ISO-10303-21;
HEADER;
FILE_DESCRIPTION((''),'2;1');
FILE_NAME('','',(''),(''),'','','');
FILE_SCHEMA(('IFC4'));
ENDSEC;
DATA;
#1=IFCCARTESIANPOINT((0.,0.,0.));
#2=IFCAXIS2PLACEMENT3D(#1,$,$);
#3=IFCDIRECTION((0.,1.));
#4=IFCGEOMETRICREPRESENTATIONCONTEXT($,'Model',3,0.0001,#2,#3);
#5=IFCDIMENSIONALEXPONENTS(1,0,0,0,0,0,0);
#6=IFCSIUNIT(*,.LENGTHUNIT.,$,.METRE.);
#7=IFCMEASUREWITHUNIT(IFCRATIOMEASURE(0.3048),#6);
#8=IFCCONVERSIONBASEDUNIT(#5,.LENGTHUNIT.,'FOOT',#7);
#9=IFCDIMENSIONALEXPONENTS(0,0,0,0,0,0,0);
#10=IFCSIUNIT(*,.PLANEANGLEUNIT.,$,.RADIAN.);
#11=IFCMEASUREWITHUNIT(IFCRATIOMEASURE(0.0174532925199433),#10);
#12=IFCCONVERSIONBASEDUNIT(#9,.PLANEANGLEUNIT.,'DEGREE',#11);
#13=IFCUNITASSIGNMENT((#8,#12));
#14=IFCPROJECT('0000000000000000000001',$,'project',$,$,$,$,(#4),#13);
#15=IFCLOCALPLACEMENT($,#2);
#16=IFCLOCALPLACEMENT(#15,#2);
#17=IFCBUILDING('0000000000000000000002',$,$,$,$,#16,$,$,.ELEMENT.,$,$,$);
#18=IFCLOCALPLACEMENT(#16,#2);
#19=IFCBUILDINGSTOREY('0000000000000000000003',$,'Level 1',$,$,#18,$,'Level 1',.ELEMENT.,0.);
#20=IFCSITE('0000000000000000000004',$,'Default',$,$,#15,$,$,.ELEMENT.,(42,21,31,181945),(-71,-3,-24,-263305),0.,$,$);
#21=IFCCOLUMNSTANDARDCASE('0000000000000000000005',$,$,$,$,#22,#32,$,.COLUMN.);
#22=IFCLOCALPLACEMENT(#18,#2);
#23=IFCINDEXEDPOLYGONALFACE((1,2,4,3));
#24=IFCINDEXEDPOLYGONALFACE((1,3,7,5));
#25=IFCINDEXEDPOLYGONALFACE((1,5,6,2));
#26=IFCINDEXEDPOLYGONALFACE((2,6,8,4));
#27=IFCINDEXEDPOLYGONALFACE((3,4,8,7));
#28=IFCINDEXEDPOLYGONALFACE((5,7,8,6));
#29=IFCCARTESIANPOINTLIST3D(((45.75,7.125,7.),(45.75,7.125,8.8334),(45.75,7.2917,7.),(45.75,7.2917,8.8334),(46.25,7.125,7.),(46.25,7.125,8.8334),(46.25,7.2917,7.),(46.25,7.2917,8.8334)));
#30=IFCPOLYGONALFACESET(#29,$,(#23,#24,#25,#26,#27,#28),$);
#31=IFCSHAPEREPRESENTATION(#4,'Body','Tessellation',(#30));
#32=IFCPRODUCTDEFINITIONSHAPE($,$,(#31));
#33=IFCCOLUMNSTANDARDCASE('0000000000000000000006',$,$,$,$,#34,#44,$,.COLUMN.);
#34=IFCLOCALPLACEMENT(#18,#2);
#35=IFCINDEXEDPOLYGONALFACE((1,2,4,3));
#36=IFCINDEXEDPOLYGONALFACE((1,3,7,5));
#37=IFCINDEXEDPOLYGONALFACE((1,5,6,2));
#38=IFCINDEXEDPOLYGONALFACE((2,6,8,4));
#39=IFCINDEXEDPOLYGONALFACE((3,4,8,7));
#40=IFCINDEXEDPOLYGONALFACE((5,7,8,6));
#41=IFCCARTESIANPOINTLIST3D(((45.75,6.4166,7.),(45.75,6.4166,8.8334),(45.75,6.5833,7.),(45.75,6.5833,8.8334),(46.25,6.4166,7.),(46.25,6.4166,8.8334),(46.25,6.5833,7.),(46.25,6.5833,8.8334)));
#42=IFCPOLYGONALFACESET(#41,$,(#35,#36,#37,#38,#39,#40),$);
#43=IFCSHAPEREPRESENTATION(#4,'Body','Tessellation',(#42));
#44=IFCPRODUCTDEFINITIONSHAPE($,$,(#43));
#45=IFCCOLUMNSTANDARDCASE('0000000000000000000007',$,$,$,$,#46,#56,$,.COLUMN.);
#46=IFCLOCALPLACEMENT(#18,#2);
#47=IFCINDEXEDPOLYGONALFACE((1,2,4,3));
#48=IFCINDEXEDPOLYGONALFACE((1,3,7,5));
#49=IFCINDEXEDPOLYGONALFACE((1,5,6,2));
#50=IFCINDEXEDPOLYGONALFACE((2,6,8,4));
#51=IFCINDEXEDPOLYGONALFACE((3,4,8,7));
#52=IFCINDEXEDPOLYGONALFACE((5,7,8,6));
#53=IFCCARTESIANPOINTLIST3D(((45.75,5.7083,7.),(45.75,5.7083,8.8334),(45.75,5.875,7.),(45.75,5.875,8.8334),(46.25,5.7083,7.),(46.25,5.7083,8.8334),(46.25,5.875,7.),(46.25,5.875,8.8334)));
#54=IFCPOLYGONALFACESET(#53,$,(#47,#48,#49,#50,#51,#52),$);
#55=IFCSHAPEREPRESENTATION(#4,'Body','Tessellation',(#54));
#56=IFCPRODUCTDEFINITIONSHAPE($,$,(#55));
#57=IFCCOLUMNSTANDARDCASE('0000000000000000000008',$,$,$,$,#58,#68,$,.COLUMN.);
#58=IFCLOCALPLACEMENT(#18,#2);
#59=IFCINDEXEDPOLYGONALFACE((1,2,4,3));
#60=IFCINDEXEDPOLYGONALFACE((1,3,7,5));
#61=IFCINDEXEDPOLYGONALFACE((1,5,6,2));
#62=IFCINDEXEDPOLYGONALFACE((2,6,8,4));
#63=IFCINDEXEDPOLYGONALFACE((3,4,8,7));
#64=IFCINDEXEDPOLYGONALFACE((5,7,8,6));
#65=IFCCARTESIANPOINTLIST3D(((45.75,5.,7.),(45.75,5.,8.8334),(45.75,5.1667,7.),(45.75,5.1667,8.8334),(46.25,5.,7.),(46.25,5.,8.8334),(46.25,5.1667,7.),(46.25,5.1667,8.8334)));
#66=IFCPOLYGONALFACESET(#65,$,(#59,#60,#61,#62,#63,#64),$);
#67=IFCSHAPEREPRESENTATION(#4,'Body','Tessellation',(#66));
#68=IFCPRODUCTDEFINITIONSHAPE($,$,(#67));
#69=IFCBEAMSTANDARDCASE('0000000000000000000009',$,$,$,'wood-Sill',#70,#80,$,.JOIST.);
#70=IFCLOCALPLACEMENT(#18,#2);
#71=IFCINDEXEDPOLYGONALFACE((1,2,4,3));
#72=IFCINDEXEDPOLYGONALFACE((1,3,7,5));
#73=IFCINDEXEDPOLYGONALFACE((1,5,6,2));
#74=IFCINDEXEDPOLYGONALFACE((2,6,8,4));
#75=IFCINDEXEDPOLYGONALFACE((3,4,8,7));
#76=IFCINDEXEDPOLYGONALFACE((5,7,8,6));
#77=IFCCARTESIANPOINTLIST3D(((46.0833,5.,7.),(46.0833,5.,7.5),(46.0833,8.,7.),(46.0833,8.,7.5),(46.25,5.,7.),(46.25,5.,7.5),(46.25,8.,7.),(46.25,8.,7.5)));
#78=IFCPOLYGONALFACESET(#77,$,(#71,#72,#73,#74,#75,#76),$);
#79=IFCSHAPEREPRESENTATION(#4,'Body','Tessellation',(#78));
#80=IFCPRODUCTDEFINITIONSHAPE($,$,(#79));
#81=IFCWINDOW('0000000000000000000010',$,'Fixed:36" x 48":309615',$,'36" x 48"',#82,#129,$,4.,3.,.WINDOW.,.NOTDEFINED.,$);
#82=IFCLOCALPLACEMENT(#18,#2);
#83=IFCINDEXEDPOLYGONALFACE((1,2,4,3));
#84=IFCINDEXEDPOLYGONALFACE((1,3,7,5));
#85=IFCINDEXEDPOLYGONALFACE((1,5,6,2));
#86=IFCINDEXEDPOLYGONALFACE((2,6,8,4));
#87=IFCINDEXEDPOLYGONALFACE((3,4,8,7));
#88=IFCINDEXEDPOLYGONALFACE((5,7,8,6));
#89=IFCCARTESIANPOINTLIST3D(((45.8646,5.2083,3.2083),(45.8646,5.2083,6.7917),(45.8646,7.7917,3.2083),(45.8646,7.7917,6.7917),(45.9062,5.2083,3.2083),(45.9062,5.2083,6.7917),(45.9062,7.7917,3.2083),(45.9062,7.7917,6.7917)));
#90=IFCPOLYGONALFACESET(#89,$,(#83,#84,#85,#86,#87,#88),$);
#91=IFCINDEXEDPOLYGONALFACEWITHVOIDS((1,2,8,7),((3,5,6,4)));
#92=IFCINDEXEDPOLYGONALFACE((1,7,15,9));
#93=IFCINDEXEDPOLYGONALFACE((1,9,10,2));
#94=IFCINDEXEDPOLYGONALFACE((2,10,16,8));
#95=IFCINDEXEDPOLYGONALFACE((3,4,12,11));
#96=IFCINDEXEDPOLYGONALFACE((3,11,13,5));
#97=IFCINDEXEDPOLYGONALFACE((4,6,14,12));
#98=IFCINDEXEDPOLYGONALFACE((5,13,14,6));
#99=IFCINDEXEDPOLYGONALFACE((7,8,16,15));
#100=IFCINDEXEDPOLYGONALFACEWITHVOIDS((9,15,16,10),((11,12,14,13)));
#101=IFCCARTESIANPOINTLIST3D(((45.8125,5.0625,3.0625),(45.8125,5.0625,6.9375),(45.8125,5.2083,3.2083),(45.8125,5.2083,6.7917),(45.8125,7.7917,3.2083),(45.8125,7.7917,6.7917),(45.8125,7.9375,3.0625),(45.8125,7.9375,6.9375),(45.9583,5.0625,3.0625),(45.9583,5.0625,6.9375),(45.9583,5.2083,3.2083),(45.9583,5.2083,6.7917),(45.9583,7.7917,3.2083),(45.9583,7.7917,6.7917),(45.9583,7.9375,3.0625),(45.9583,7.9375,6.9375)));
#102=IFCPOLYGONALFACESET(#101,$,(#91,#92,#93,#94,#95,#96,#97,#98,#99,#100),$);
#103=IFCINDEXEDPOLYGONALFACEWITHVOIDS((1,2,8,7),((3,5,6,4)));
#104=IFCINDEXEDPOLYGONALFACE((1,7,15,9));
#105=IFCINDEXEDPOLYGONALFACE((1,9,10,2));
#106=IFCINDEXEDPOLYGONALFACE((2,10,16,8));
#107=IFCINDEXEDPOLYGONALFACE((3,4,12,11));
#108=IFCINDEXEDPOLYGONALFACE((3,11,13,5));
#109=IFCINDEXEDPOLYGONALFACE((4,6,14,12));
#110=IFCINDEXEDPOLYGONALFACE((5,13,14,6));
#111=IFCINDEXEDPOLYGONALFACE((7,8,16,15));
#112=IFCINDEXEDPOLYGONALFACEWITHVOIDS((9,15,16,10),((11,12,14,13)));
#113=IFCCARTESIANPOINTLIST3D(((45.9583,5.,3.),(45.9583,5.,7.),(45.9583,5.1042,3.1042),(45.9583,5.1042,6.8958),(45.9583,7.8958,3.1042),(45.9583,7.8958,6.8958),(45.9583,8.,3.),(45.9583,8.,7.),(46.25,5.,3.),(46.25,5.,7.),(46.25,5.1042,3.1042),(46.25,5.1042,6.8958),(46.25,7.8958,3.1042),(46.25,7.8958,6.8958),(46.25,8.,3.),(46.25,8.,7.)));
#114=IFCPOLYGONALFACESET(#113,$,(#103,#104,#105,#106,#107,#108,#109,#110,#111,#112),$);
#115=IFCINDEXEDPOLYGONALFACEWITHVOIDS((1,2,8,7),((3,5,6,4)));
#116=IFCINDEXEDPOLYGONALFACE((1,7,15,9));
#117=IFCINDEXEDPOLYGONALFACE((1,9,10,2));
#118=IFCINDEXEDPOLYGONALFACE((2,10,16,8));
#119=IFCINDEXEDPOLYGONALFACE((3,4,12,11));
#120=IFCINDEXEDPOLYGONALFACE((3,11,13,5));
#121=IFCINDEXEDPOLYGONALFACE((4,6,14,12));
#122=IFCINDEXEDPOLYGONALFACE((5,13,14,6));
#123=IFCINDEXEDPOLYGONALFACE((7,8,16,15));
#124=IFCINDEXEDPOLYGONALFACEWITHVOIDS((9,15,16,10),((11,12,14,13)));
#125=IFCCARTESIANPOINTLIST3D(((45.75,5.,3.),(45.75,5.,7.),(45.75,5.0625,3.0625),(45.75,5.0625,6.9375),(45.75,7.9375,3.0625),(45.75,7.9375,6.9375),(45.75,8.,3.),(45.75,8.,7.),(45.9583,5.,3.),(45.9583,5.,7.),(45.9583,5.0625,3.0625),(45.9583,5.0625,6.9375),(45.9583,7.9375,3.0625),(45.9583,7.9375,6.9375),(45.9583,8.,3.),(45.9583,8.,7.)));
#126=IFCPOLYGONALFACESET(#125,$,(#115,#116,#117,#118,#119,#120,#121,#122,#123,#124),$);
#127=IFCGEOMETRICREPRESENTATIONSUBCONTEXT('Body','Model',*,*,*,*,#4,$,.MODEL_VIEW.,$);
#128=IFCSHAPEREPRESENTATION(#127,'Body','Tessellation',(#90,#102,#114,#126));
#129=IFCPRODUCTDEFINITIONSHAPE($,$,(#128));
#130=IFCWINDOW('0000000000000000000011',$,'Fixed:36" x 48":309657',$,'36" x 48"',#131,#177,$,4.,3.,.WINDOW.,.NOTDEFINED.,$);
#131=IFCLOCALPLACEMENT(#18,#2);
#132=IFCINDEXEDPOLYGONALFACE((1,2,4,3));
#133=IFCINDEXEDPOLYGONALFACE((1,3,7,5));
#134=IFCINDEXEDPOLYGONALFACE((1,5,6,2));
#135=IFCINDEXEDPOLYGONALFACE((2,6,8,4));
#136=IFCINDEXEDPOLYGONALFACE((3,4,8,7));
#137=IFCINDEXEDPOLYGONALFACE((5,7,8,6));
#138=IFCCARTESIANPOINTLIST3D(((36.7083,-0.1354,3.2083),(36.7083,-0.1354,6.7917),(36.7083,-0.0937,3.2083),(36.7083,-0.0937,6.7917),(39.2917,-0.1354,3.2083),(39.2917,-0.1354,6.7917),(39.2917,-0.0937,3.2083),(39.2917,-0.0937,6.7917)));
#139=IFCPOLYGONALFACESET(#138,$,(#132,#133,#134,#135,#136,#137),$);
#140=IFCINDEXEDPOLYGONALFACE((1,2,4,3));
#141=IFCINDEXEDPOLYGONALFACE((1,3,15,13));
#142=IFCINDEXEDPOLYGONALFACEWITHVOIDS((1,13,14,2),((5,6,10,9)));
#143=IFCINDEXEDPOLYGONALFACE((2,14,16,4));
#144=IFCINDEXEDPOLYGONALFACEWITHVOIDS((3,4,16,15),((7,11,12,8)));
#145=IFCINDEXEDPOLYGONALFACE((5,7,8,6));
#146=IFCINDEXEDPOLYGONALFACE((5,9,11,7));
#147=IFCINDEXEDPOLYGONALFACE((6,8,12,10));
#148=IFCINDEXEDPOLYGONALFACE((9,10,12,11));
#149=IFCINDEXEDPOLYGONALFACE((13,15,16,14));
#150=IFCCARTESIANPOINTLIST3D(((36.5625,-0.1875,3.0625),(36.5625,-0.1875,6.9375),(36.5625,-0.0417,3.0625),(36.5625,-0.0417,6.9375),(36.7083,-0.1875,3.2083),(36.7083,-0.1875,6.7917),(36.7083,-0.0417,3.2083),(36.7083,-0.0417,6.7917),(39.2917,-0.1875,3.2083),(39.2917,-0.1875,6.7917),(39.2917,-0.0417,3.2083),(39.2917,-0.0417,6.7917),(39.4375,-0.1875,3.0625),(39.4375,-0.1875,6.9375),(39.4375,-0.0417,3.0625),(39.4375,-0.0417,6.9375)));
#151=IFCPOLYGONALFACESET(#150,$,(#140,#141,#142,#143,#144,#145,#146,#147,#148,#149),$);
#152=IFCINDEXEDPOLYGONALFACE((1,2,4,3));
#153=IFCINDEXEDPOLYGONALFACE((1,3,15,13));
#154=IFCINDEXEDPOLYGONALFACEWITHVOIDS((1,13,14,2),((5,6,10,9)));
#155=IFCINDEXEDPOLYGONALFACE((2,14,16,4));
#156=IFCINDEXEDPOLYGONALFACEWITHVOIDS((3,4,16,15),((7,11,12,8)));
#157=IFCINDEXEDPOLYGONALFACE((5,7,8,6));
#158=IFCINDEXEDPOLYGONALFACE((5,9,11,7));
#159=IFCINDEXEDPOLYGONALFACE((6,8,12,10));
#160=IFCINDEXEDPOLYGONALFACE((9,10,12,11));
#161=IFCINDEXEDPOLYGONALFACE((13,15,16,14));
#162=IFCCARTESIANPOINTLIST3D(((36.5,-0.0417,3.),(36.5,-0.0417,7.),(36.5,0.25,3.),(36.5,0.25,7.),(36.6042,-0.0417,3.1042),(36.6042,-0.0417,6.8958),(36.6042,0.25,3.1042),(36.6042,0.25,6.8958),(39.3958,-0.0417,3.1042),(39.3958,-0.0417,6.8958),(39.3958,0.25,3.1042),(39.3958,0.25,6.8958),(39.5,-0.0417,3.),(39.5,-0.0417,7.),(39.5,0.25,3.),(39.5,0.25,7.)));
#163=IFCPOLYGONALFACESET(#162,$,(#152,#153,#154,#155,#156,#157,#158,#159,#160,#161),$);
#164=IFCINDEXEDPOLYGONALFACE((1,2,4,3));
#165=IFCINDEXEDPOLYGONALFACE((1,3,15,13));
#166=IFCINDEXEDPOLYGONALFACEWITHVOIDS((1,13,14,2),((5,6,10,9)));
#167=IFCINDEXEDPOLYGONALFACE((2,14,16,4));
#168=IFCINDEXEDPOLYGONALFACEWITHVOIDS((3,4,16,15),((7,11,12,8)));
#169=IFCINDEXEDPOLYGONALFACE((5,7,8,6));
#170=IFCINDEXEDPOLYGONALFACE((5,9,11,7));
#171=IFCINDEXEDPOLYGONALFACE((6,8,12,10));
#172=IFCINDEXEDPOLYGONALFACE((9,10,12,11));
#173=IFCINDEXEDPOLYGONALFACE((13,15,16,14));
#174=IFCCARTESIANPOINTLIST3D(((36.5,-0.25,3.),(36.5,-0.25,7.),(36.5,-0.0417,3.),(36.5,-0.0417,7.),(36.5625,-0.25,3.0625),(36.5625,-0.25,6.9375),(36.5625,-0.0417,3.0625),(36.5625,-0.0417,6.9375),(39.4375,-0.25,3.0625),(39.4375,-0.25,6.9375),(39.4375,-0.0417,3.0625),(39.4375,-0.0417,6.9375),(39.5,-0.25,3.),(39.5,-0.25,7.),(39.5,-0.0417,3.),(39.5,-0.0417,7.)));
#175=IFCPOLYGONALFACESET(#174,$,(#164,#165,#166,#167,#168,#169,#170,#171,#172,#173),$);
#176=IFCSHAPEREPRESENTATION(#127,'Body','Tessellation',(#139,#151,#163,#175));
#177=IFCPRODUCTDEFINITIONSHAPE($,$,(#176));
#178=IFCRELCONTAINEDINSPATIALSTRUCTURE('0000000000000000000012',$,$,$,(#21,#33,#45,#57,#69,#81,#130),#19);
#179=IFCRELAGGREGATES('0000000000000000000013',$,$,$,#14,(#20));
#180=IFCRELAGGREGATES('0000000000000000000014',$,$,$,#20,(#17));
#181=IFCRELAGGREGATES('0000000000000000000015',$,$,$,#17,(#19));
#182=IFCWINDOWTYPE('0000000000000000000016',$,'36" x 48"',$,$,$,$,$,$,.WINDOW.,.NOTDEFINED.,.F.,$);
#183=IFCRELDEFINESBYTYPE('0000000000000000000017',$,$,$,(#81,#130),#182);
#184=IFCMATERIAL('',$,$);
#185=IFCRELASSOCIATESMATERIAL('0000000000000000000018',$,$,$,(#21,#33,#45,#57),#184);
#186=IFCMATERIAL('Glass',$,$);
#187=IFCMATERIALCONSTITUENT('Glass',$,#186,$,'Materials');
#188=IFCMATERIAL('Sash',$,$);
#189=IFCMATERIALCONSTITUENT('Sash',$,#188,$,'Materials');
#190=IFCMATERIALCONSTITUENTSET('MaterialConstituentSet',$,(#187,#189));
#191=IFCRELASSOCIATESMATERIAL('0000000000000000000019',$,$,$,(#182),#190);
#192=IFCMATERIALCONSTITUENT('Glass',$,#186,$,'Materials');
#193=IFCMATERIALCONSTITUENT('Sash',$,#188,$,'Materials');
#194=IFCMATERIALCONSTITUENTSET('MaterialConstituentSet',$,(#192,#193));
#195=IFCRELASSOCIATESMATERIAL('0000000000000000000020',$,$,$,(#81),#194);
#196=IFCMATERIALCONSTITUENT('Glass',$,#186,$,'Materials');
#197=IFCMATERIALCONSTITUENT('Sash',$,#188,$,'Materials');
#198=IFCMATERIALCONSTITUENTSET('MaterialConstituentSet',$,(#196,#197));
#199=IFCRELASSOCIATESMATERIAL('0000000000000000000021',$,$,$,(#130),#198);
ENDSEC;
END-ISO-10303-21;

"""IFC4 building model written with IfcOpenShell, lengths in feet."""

from ifc_helpers import new_model, entity, si_unit, converted_unit, direction, frame, frame_2d, origin, origin_with_axes, place, context, subcontext, project, spatial, polyline, rectangle, outline, extrude, source, transform, mapped, material, constituent, constituent_set, type_object, type_shapes, element, save


model = new_model("IFC4")

# Units and contexts
model_context = context("Model", 3, precision=0.0001, world=origin(), true_north=direction((0.0, 1.0)))
body_context = subcontext(model_context, "Body", "Model", "MODEL_VIEW")
ifc_project = project(units=[converted_unit("LENGTHUNIT", "FOOT", entity("IfcRatioMeasure", 0.3048), si_unit("LENGTHUNIT", "METRE"), dimensions=[1, 0, 0, 0, 0, 0, 0]), converted_unit("PLANEANGLEUNIT", "DEGREE", entity("IfcRatioMeasure", 0.0174532925199433), si_unit("PLANEANGLEUNIT", "RADIAN"), dimensions=[0, 0, 0, 0, 0, 0, 0])], contexts=[model_context])

# Site, building, storey
site_placement = place(None, origin())
site = spatial("IfcSite", under=ifc_project, at=site_placement, Name="Default", CompositionType="ELEMENT", RefLatitude=(42, 21, 31, 181945), RefLongitude=(-71, -3, -24, -263305), RefElevation=0.0)
building_placement = place(site_placement, origin())
building = spatial("IfcBuilding", under=site, at=building_placement, CompositionType="ELEMENT")
storey_placement = place(building_placement, origin())
storey = spatial("IfcBuildingStorey", under=building, at=storey_placement, Name="Level 1", LongName="Level 1", CompositionType="ELEMENT", Elevation=0.0)

# Columns
placement_1 = place(storey_placement, frame((46.0, 46.25, 0.0), z_axis=(0.0, 0.0, 1.0), x_axis=(0.0, -1.0, 0.0)))
ifc_material_1 = material(Name="")
for number, where, z_axis, x_axis in (
    (1, (39.0417, 0.0, 7.0), (0.0, 0.0, 1.0), (1.0, 0.0, 0.0)),
    (2, (39.7501, 0.0, 7.0), (0.0, 0.0, 1.0), (1.0, 0.0, 0.0)),
    (3, (40.4584, 0.0, 7.0), (0.0, 0.0, 1.0), (1.0, 0.0, 0.0)),
    (4, (41.1667, 0.0, 7.0), (0.0, 0.0, 1.0), (1.0, 0.0, 0.0)),
):
    element("IfcColumnStandardCase", number, at=place(placement_1, frame(where, z_axis=z_axis, x_axis=x_axis)), inside=storey, material=ifc_material_1, PredefinedType="COLUMN", context=model_context, shape_type="SweptSolid", body=[
        extrude(rectangle(XDim=0.1667, YDim=0.5), origin(), (0.0, 0.0, 1.0), 1.8334),
    ])

# Beam
for number, where, z_axis, x_axis in (
    (5, (38.25, 0.1667, 7.25), (1.0, 0.0, 0.0), (0.0, 0.0, 1.0)),
):
    element("IfcBeamStandardCase", number, at=place(placement_1, frame(where, z_axis=z_axis, x_axis=x_axis)), inside=storey, ObjectType="wood-Sill", PredefinedType="JOIST", context=model_context, shape_type="SweptSolid", body=[
        extrude(rectangle(XDim=0.5, YDim=0.1667), origin_with_axes(), (0.0, 0.0, 1.0), 3.0),
    ])

# Windows
ifc_material_2 = material(Name="Glass")
ifc_constituent_1 = constituent(ifc_material_2, Name="Glass", Category="Materials")
ifc_material_3 = material(Name="Sash")
ifc_constituent_2 = constituent(ifc_material_3, Name="Sash", Category="Materials")
ifc_constituent_set_1 = constituent_set(constituents=[ifc_constituent_1, ifc_constituent_2], Name="MaterialConstituentSet")
ifc_constituent_3 = constituent(ifc_material_2, Name="Glass", Category="Materials")
ifc_constituent_4 = constituent(ifc_material_3, Name="Sash", Category="Materials")
ifc_constituent_set_2 = constituent_set(constituents=[ifc_constituent_3, ifc_constituent_4], Name="MaterialConstituentSet")
window_type = type_object("IfcWindowType", Name="36\" x 48\"", ParameterTakesPrecedence=False, PartitioningType="NOTDEFINED", PredefinedType="WINDOW", material=ifc_constituent_set_2)
shared_shape = source(origin(), body_context, "Body", "SweptSolid", [
    extrude(rectangle(XDim=0.0417, YDim=2.5833, at=frame_2d((0.0, 0.0), x_axis=(1.0, 0.0))), frame((1.5, 0.3646, 0.2083), z_axis=(0.0, 0.0, 1.0), x_axis=(0.0, 1.0, 0.0)), (0.0, 0.0, 1.0), 3.5833),
    extrude(outline(polyline([(-1.4375, -1.9375), (1.4375, -1.9375), (1.4375, 1.9375), (-1.4375, 1.9375), (-1.4375, -1.9375)]), holes=[polyline([(-1.2917, -1.7917), (-1.2917, 1.7917), (1.2917, 1.7917), (1.2917, -1.7917), (-1.2917, -1.7917)])]), frame((1.5, 0.2917, 2.0), z_axis=(0.0, 1.0, 0.0), x_axis=(1.0, 0.0, 0.0)), (0.0, 0.0, 1.0), 0.1458),
    extrude(outline(polyline([(-1.5, -2.0), (1.5, -2.0), (1.5, 2.0), (-1.5, 2.0), (-1.5, -2.0)]), holes=[polyline([(-1.3958, -1.8958), (-1.3958, 1.8958), (1.3958, 1.8958), (1.3958, -1.8958), (-1.3958, -1.8958)])]), frame((1.5, 0.0, 2.0), z_axis=(0.0, 1.0, 0.0), x_axis=(1.0, 0.0, 0.0)), (0.0, 0.0, 1.0), 0.2917),
    extrude(outline(polyline([(-2.0, -1.5), (2.0, -1.5), (2.0, 1.5), (-2.0, 1.5), (-2.0, -1.5)]), holes=[polyline([(-1.9375, -1.4375), (-1.9375, 1.4375), (1.9375, 1.4375), (1.9375, -1.4375), (-1.9375, -1.4375)])]), frame((1.5, 0.2917, 2.0), z_axis=(0.0, 1.0, 0.0), x_axis=(0.0, 0.0, -1.0)), (0.0, 0.0, 1.0), 0.2083),
])
type_shapes(window_type, [shared_shape])
placement_2 = place(placement_1, frame((41.25, 0.25, 3.0)))
window_1_placement = place(placement_2, frame((0.0, 0.0, 0.0), z_axis=(0.0, 0.0, 1.0), x_axis=(-1.0, 0.0, 0.0)))
element("IfcWindow", 6, at=window_1_placement, inside=storey, type_object=window_type, material=ifc_constituent_set_1, Name="Fixed:36\" x 48\":309615", ObjectType="36\" x 48\"", OverallHeight=4.0, OverallWidth=3.0, PartitioningType="NOTDEFINED", PredefinedType="WINDOW", context=body_context, shape_type="MappedRepresentation", body=[
    mapped(shared_shape, transform((0.0, 0.0, 0.0), scale=1.0)),
])
ifc_constituent_5 = constituent(ifc_material_2, Name="Glass", Category="Materials")
ifc_constituent_6 = constituent(ifc_material_3, Name="Sash", Category="Materials")
ifc_constituent_set_3 = constituent_set(constituents=[ifc_constituent_5, ifc_constituent_6], Name="MaterialConstituentSet")
placement_3 = place(storey_placement, frame((46.25, 0.0, 0.0), z_axis=(0.0, 0.0, 1.0), x_axis=(-1.0, 0.0, 0.0)))
placement_4 = place(placement_3, frame((6.75, -0.25, 3.0)))
window_2_placement = place(placement_4, origin())
element("IfcWindow", 7, at=window_2_placement, inside=storey, type_object=window_type, material=ifc_constituent_set_3, Name="Fixed:36\" x 48\":309657", ObjectType="36\" x 48\"", OverallHeight=4.0, OverallWidth=3.0, PartitioningType="NOTDEFINED", PredefinedType="WINDOW", context=body_context, shape_type="MappedRepresentation", body=[
    mapped(shared_shape, transform((0.0, 0.0, 0.0), scale=1.0)),
])

save(model, "model.ifc")
